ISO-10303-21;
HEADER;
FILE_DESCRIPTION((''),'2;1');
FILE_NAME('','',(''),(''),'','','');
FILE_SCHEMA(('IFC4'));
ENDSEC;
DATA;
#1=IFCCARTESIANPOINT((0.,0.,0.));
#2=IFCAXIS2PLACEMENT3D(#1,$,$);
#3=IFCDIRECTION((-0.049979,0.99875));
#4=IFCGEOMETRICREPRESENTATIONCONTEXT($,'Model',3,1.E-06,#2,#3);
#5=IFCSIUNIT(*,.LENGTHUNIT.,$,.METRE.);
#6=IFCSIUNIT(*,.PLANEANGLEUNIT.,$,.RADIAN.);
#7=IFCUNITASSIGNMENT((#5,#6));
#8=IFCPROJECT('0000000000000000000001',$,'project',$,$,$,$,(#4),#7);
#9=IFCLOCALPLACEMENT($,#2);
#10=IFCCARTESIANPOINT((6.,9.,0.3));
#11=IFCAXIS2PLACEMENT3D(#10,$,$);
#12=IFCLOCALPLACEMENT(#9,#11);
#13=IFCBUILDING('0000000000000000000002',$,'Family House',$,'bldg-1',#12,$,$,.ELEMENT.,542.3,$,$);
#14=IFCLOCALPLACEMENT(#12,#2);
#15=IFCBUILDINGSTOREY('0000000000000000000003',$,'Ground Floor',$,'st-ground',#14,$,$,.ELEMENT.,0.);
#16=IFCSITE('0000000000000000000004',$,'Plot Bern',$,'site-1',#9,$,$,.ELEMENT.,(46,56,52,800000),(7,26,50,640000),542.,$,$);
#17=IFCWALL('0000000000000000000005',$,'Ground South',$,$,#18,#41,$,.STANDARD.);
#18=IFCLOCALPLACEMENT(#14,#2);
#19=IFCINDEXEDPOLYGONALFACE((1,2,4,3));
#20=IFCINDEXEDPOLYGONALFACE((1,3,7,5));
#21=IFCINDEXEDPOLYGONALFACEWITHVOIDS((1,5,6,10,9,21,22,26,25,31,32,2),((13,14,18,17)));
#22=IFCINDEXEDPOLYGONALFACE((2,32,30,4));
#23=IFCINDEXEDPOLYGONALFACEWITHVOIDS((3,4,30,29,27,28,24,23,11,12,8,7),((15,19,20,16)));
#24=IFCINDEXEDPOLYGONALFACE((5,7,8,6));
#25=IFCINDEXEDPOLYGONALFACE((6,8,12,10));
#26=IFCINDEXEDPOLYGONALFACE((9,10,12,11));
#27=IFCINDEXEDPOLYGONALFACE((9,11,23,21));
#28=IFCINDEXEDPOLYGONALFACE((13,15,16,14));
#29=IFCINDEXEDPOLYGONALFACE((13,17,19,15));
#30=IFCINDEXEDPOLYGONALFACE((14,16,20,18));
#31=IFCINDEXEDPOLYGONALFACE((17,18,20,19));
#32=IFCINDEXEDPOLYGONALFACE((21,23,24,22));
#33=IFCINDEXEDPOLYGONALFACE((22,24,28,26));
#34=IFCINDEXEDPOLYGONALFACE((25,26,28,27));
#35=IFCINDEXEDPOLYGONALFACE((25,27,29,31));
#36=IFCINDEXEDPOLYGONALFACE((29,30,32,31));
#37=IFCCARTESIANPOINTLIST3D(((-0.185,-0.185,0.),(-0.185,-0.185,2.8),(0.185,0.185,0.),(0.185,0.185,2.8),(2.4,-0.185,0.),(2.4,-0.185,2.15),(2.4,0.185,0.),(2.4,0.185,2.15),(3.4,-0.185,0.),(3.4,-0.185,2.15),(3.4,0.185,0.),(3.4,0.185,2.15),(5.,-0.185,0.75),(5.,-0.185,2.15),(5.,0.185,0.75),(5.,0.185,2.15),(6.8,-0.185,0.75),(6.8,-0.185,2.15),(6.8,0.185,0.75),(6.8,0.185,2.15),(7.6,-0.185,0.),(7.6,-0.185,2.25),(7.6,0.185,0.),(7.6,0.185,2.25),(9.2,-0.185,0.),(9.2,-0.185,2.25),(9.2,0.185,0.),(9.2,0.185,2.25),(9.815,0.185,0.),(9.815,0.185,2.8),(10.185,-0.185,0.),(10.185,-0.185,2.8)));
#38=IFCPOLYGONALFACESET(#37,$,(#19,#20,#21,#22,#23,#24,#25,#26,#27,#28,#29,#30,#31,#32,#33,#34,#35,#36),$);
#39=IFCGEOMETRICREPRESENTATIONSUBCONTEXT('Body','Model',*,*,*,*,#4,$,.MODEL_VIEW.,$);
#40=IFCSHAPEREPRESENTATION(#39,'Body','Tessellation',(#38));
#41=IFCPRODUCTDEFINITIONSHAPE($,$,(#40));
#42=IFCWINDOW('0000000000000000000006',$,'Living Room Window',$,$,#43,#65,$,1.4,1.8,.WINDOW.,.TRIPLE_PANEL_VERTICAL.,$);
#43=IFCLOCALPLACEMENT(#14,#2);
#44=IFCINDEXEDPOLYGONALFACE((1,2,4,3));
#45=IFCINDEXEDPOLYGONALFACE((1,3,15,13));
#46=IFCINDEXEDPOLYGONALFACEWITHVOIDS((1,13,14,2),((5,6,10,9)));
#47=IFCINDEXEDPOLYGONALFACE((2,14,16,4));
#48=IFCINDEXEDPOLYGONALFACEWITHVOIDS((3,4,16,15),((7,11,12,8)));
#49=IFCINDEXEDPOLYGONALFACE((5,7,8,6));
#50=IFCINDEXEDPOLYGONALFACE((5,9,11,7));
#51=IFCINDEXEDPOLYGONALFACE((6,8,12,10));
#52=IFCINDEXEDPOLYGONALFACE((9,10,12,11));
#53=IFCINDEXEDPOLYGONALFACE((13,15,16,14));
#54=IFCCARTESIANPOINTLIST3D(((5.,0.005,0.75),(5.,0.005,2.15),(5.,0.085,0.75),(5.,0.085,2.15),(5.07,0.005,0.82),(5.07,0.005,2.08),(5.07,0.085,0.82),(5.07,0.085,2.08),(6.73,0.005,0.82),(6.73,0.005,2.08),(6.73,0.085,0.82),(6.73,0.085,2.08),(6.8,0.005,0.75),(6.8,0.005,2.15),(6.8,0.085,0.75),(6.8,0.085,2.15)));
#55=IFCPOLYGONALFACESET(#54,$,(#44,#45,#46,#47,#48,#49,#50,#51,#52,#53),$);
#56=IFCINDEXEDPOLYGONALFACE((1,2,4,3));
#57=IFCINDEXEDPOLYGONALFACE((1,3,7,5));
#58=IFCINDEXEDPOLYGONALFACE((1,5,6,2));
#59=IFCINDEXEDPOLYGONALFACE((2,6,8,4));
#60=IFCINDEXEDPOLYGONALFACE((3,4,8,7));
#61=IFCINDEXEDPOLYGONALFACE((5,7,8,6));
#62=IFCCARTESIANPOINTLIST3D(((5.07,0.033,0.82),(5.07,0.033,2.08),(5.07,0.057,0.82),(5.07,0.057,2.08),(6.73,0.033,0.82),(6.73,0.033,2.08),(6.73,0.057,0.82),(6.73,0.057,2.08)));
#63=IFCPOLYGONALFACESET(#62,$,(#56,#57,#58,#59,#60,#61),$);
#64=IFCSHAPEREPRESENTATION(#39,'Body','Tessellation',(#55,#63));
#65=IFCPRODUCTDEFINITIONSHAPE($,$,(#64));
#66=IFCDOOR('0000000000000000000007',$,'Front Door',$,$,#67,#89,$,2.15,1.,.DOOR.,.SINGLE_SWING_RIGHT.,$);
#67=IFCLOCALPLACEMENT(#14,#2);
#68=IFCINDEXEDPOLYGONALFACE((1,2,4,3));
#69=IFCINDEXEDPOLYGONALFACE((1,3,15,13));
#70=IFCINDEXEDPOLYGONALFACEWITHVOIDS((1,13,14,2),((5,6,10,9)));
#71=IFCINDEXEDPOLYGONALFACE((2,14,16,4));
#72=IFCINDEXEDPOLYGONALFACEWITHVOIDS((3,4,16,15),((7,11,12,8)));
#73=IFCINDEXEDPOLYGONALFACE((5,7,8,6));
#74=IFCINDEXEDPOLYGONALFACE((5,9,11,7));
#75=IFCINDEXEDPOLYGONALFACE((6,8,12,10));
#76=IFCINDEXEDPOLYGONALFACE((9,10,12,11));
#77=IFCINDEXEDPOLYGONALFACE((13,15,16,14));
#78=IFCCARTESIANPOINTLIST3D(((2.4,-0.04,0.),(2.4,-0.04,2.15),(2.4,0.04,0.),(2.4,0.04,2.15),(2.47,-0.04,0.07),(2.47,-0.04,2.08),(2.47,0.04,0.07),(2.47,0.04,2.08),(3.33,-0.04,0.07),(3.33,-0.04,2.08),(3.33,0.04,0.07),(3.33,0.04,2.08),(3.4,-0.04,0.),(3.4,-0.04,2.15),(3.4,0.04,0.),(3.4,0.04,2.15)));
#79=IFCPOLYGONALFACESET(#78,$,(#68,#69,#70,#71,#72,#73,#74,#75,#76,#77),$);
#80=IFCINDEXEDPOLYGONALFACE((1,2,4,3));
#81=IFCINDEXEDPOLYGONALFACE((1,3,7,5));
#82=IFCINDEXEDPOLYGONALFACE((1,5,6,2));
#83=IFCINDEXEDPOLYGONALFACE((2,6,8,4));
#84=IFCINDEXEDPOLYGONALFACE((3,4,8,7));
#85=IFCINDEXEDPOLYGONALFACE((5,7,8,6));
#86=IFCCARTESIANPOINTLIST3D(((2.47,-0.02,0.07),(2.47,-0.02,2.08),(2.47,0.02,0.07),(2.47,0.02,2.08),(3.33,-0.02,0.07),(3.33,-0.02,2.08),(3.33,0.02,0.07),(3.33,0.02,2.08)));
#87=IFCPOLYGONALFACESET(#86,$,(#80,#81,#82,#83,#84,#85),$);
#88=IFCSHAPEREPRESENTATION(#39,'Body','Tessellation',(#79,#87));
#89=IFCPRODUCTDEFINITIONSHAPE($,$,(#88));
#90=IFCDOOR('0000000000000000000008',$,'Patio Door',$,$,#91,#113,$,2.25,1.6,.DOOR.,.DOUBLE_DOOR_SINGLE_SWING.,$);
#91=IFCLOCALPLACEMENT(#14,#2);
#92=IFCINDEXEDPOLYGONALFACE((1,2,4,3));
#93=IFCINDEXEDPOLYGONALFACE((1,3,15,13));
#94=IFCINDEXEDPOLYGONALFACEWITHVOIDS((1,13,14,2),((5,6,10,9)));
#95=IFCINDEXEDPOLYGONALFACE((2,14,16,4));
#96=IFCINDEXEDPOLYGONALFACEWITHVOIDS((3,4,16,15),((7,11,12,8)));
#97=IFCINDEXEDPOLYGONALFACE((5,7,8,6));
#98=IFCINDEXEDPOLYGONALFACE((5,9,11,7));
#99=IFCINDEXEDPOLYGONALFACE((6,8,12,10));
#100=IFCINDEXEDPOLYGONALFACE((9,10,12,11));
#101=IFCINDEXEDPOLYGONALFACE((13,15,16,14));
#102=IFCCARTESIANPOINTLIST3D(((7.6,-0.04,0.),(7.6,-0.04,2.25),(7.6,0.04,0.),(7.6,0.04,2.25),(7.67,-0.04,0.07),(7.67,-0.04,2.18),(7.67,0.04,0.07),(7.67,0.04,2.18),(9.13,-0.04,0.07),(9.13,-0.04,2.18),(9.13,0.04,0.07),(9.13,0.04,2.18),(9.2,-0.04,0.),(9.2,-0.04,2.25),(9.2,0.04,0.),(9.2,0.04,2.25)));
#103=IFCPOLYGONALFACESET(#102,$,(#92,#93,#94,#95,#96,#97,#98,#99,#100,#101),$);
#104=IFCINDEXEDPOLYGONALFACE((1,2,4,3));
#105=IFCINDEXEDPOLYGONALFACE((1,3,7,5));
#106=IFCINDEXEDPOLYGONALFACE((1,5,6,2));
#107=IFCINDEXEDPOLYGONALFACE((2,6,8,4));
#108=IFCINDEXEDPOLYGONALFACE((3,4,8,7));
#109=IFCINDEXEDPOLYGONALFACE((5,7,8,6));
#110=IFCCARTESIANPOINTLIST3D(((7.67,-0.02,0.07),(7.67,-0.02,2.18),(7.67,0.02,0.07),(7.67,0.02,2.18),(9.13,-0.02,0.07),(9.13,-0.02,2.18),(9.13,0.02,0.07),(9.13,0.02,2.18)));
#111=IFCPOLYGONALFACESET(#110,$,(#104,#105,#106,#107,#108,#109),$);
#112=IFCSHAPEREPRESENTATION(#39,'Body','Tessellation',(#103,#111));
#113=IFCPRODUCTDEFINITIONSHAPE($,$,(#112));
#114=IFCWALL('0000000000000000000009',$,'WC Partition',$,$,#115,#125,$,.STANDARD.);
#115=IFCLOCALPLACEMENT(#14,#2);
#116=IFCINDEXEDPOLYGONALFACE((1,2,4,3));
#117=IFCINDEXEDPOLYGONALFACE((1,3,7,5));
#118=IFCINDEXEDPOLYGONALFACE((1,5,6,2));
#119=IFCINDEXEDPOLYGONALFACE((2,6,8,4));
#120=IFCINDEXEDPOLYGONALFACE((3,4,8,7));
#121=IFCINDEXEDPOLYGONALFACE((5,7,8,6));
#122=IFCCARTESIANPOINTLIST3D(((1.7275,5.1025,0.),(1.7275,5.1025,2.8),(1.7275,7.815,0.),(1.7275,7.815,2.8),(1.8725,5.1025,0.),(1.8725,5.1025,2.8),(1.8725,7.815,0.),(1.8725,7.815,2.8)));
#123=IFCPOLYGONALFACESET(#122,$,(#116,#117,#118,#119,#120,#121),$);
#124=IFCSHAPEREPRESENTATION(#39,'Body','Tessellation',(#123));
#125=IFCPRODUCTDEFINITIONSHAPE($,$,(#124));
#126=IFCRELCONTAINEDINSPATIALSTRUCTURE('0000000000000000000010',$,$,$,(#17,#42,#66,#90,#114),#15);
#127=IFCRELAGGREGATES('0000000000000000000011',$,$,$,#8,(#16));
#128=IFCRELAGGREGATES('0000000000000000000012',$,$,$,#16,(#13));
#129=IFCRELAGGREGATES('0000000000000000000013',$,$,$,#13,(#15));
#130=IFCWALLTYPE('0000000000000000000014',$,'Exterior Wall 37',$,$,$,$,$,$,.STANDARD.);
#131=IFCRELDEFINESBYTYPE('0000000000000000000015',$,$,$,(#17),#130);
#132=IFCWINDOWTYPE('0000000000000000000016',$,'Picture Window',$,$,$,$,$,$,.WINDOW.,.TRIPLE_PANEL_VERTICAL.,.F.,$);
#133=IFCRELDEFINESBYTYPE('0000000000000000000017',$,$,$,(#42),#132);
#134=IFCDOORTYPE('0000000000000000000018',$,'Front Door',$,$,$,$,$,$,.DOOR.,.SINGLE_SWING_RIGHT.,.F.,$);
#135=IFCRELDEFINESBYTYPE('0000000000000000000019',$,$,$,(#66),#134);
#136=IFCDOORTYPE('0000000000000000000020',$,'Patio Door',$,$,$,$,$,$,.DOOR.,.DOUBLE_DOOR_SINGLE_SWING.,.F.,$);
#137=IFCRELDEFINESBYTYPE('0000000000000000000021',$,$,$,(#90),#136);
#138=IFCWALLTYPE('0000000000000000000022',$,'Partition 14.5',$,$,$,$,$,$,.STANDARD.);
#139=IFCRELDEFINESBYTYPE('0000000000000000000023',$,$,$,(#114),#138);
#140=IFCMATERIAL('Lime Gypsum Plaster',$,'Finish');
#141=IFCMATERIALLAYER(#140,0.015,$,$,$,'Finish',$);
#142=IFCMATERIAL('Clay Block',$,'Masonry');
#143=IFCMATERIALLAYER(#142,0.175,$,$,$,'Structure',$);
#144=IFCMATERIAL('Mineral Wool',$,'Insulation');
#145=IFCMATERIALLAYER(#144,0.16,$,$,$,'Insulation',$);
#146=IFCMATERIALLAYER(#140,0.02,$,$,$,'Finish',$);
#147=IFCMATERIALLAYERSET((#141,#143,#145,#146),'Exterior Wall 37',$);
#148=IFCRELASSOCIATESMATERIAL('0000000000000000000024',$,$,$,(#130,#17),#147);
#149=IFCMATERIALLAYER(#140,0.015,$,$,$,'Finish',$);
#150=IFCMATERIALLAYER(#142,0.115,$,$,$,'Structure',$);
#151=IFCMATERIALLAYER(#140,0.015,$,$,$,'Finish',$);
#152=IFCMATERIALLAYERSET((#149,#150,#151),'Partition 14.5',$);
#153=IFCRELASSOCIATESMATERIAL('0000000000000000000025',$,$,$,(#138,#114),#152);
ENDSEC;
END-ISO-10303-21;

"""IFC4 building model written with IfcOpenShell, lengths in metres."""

from ifc_helpers import new_model, si_unit, direction, frame, frame_2d, origin, origin_2d, place, context, subcontext, project, spatial, polyline, rectangle, outline, extrude, material, layer, layer_set, layer_usage, type_object, element, fill, save


model = new_model("IFC4")

# Units and contexts
model_context = context("Model", 3, precision=1e-06, world=origin(), true_north=direction((-0.049979, 0.99875)))
body_context = subcontext(model_context, "Body", "Model", "MODEL_VIEW")
ifc_project = project(units=[si_unit("LENGTHUNIT", "METRE"), si_unit("PLANEANGLEUNIT", "RADIAN")], contexts=[model_context])

# Site, building, storey
site_placement = place(None, origin())
site = spatial("IfcSite", under=ifc_project, at=site_placement, Name="Plot Bern", ObjectType="site-1", CompositionType="ELEMENT", RefLatitude=(46, 56, 52, 800000), RefLongitude=(7, 26, 50, 640000), RefElevation=542.0)
building_placement = place(site_placement, frame((6.0, 9.0, 0.3)))
building = spatial("IfcBuilding", under=site, at=building_placement, Name="Family House", ObjectType="bldg-1", CompositionType="ELEMENT", ElevationOfRefHeight=542.3)
storey_placement = place(building_placement, origin())
storey = spatial("IfcBuildingStorey", under=building, at=storey_placement, Name="Ground Floor", ObjectType="st-ground", CompositionType="ELEMENT", Elevation=0.0)

# Shared definitions
ifc_material_1 = material(Name="Mineral Wool", Category="Insulation")

# Shared definitions
ifc_material_2 = material(Name="Lime Gypsum Plaster", Category="Finish")
ifc_layer_1 = layer(ifc_material_2, 0.015, Category="Finish")
ifc_material_3 = material(Name="Clay Block", Category="Masonry")
ifc_layer_2 = layer(ifc_material_3, 0.175, Category="Structure")
ifc_layer_3 = layer(ifc_material_1, 0.16, Category="Insulation")
ifc_layer_4 = layer(ifc_material_2, 0.02, Category="Finish")
ifc_layer_set_1 = layer_set([ifc_layer_1, ifc_layer_2, ifc_layer_3, ifc_layer_4], Name="Exterior Wall 37")
wall_type_1 = type_object("IfcWallType", Name="Exterior Wall 37", PredefinedType="STANDARD", material=ifc_layer_set_1)

# Wall, openings, window, doors
ifc_layer_usage_1 = layer_usage(ifc_layer_set_1, "AXIS2", "NEGATIVE", 0.185)
wall_1_placement = place(storey_placement, origin())
wall_1 = element("IfcWall", 1, at=wall_1_placement, inside=storey, type_object=wall_type_1, material=ifc_layer_usage_1, Name="Ground South", PredefinedType="STANDARD", context=body_context, shape_type="SweptSolid", body=[
    extrude(outline(polyline([(-0.185, -0.185), (10.185, -0.185), (9.815, 0.185), (0.185, 0.185), (-0.185, -0.185)])), origin(), (0.0, 0.0, 1.0), 2.8),
])
opening_1_placement = place(wall_1_placement, frame((2.9, 0.0, 0.0), z_axis=(0.0, 0.0, 1.0), x_axis=(1.0, 0.0, 0.0)))
opening_1 = element("IfcOpeningElement", 2, at=opening_1_placement, cuts=wall_1, PredefinedType="OPENING", context=body_context, shape_type="SweptSolid", body=[
    extrude(rectangle(XDim=1.0, YDim=0.37, at=origin_2d()), origin(), (0.0, 0.0, 1.0), 2.15),
])
opening_2_placement = place(wall_1_placement, frame((5.9, 0.0, 0.75), z_axis=(0.0, 0.0, 1.0), x_axis=(1.0, 0.0, 0.0)))
opening_2 = element("IfcOpeningElement", 3, at=opening_2_placement, cuts=wall_1, PredefinedType="OPENING", context=body_context, shape_type="SweptSolid", body=[
    extrude(rectangle(XDim=1.8, YDim=0.37, at=origin_2d()), origin(), (0.0, 0.0, 1.0), 1.4),
])
opening_3_placement = place(wall_1_placement, frame((8.4, 0.0, 0.0), z_axis=(0.0, 0.0, 1.0), x_axis=(1.0, 0.0, 0.0)))
opening_3 = element("IfcOpeningElement", 4, at=opening_3_placement, cuts=wall_1, PredefinedType="OPENING", context=body_context, shape_type="SweptSolid", body=[
    extrude(rectangle(XDim=1.6, YDim=0.37, at=origin_2d()), origin(), (0.0, 0.0, 1.0), 2.25),
])
window_type_1 = type_object("IfcWindowType", Name="Picture Window", ParameterTakesPrecedence=False, PartitioningType="TRIPLE_PANEL_VERTICAL", PredefinedType="WINDOW")
window_1_placement = place(opening_2_placement, frame((0.0, 0.045, 0.0), z_axis=(0.0, -1.0, 0.0), x_axis=(1.0, 0.0, 0.0)))
window_1 = element("IfcWindow", 5, at=window_1_placement, inside=storey, type_object=window_type_1, Name="Living Room Window", OverallHeight=1.4, OverallWidth=1.8, PartitioningType="TRIPLE_PANEL_VERTICAL", PredefinedType="WINDOW", context=body_context, shape_type="SweptSolid", body=[
    extrude(outline(polyline([(-0.9, 0.0), (0.9, 0.0), (0.9, 1.4), (-0.9, 1.4), (-0.9, 0.0)]), holes=[polyline([(-0.83, 0.07), (0.83, 0.07), (0.83, 1.33), (-0.83, 1.33), (-0.83, 0.07)])]), frame((0.0, 0.0, -0.04)), (0.0, 0.0, 1.0), 0.08),
    extrude(rectangle(XDim=1.66, YDim=1.26, at=frame_2d((0.0, 0.7))), frame((0.0, 0.0, -0.012)), (0.0, 0.0, 1.0), 0.024),
])
fill(opening_2, window_1)
door_type_1 = type_object("IfcDoorType", Name="Front Door", OperationType="SINGLE_SWING_RIGHT", ParameterTakesPrecedence=False, PredefinedType="DOOR")
door_1_placement = place(opening_1_placement, frame((0.0, 0.0, 0.0), z_axis=(0.0, -1.0, 0.0), x_axis=(1.0, 0.0, 0.0)))
door_1 = element("IfcDoor", 6, at=door_1_placement, inside=storey, type_object=door_type_1, Name="Front Door", OperationType="SINGLE_SWING_RIGHT", OverallHeight=2.15, OverallWidth=1.0, PredefinedType="DOOR", context=body_context, shape_type="SweptSolid", body=[
    extrude(outline(polyline([(-0.5, 0.0), (0.5, 0.0), (0.5, 2.15), (-0.5, 2.15), (-0.5, 0.0)]), holes=[polyline([(-0.43, 0.07), (0.43, 0.07), (0.43, 2.08), (-0.43, 2.08), (-0.43, 0.07)])]), frame((0.0, 0.0, -0.04)), (0.0, 0.0, 1.0), 0.08),
    extrude(rectangle(XDim=0.86, YDim=2.01, at=frame_2d((0.0, 1.075))), frame((0.0, 0.0, -0.02)), (0.0, 0.0, 1.0), 0.04),
])
fill(opening_1, door_1)
door_type_2 = type_object("IfcDoorType", Name="Patio Door", OperationType="DOUBLE_DOOR_SINGLE_SWING", ParameterTakesPrecedence=False, PredefinedType="DOOR")
door_2_placement = place(opening_3_placement, frame((0.0, 0.0, 0.0), z_axis=(0.0, -1.0, 0.0), x_axis=(1.0, 0.0, 0.0)))
door_2 = element("IfcDoor", 7, at=door_2_placement, inside=storey, type_object=door_type_2, Name="Patio Door", OperationType="DOUBLE_DOOR_SINGLE_SWING", OverallHeight=2.25, OverallWidth=1.6, PredefinedType="DOOR", context=body_context, shape_type="SweptSolid", body=[
    extrude(outline(polyline([(-0.8, 0.0), (0.8, 0.0), (0.8, 2.25), (-0.8, 2.25), (-0.8, 0.0)]), holes=[polyline([(-0.73, 0.07), (0.73, 0.07), (0.73, 2.18), (-0.73, 2.18), (-0.73, 0.07)])]), frame((0.0, 0.0, -0.04)), (0.0, 0.0, 1.0), 0.08),
    extrude(rectangle(XDim=1.46, YDim=2.11, at=frame_2d((0.0, 1.125))), frame((0.0, 0.0, -0.02)), (0.0, 0.0, 1.0), 0.04),
])
fill(opening_3, door_2)

# Wall
ifc_layer_5 = layer(ifc_material_2, 0.015, Category="Finish")
ifc_layer_6 = layer(ifc_material_3, 0.115, Category="Structure")
ifc_layer_7 = layer(ifc_material_2, 0.015, Category="Finish")
ifc_layer_set_2 = layer_set([ifc_layer_5, ifc_layer_6, ifc_layer_7], Name="Partition 14.5")
ifc_layer_usage_2 = layer_usage(ifc_layer_set_2, "AXIS2", "NEGATIVE", 0.0725)
wall_type_2 = type_object("IfcWallType", Name="Partition 14.5", PredefinedType="STANDARD", material=ifc_layer_set_2)
wall_2_placement = place(storey_placement, origin())
element("IfcWall", 8, at=wall_2_placement, inside=storey, type_object=wall_type_2, material=ifc_layer_usage_2, Name="WC Partition", PredefinedType="STANDARD", context=body_context, shape_type="SweptSolid", body=[
    extrude(outline(polyline([(1.8725, 5.1025), (1.8725, 7.815), (1.7275, 7.815), (1.7275, 5.1025), (1.8725, 5.1025)])), origin(), (0.0, 0.0, 1.0), 2.8),
])

save(model, "model.ifc")
